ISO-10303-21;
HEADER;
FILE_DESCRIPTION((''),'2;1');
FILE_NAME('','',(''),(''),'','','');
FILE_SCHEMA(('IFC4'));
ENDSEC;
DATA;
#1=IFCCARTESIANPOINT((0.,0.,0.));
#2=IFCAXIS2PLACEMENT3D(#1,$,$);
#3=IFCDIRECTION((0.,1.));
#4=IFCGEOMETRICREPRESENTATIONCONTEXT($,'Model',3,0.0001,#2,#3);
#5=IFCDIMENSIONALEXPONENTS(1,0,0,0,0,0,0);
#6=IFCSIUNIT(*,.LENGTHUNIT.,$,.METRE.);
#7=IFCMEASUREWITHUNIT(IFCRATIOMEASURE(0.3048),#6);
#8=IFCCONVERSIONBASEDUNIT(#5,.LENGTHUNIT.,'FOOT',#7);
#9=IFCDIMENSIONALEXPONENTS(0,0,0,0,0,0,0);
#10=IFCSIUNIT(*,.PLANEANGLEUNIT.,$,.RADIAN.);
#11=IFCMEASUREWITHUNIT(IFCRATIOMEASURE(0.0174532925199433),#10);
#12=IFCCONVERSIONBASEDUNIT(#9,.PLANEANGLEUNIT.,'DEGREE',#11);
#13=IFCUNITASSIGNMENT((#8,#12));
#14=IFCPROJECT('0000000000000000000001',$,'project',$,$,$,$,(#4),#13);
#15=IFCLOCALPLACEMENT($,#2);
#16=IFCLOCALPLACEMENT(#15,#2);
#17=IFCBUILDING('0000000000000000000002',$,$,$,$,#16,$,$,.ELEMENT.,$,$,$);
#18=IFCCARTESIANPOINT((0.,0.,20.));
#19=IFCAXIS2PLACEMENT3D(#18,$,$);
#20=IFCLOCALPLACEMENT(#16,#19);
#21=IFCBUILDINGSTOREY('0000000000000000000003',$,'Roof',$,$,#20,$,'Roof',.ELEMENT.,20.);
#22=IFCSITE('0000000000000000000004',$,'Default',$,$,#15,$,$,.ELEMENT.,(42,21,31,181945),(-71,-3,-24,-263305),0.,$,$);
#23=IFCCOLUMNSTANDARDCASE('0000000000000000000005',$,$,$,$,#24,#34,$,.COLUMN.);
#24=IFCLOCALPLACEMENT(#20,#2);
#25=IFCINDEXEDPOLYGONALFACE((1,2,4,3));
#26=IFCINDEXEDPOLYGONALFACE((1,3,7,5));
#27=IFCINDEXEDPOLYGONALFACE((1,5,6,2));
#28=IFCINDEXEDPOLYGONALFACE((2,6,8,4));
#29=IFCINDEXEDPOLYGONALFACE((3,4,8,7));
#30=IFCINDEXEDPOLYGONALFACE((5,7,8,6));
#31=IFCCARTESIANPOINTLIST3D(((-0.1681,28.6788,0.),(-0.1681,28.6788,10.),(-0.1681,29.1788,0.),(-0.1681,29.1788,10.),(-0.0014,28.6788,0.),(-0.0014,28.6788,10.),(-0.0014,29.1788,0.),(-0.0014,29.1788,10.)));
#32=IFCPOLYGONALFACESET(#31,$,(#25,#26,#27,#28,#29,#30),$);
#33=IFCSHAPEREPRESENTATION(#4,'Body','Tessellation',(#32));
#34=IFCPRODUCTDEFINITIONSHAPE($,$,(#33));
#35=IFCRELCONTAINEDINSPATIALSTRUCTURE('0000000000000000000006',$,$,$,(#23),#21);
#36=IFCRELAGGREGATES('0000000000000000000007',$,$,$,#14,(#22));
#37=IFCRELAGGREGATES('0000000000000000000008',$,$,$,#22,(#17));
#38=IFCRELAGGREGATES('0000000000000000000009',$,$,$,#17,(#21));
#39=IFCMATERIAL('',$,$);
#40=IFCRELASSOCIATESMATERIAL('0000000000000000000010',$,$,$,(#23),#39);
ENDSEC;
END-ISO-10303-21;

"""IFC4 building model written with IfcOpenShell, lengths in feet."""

from ifc_helpers import new_model, entity, si_unit, converted_unit, direction, frame, origin, place, context, project, spatial, rectangle, extrude, material, element, save


model = new_model("IFC4")

# Units and contexts
model_context = context("Model", 3, precision=0.0001, world=origin(), true_north=direction((0.0, 1.0)))
ifc_project = project(units=[converted_unit("LENGTHUNIT", "FOOT", entity("IfcRatioMeasure", 0.3048), si_unit("LENGTHUNIT", "METRE"), dimensions=[1, 0, 0, 0, 0, 0, 0]), converted_unit("PLANEANGLEUNIT", "DEGREE", entity("IfcRatioMeasure", 0.0174532925199433), si_unit("PLANEANGLEUNIT", "RADIAN"), dimensions=[0, 0, 0, 0, 0, 0, 0])], contexts=[model_context])

# Site, building, storey
site_placement = place(None, origin())
site = spatial("IfcSite", under=ifc_project, at=site_placement, Name="Default", CompositionType="ELEMENT", RefLatitude=(42, 21, 31, 181945), RefLongitude=(-71, -3, -24, -263305), RefElevation=0.0)
building_placement = place(site_placement, origin())
building = spatial("IfcBuilding", under=site, at=building_placement, CompositionType="ELEMENT")
storey_placement = place(building_placement, frame((0.0, 0.0, 20.0)))
storey = spatial("IfcBuildingStorey", under=building, at=storey_placement, Name="Roof", LongName="Roof", CompositionType="ELEMENT", Elevation=20.0)

# Column
ifc_material_1 = material(Name="")
placement_1 = place(storey_placement, frame((-0.1681, 28.9288, 0.0)))
column_placement = place(placement_1, frame((0.0833, 0.0, 0.0), z_axis=(0.0, 0.0, 1.0), x_axis=(1.0, 0.0, 0.0)))
element("IfcColumnStandardCase", 1, at=column_placement, inside=storey, material=ifc_material_1, PredefinedType="COLUMN", context=model_context, shape_type="SweptSolid", body=[
    extrude(rectangle(XDim=0.1667, YDim=0.5), origin(), (0.0, 0.0, 1.0), 10.0),
])

save(model, "model.ifc")
